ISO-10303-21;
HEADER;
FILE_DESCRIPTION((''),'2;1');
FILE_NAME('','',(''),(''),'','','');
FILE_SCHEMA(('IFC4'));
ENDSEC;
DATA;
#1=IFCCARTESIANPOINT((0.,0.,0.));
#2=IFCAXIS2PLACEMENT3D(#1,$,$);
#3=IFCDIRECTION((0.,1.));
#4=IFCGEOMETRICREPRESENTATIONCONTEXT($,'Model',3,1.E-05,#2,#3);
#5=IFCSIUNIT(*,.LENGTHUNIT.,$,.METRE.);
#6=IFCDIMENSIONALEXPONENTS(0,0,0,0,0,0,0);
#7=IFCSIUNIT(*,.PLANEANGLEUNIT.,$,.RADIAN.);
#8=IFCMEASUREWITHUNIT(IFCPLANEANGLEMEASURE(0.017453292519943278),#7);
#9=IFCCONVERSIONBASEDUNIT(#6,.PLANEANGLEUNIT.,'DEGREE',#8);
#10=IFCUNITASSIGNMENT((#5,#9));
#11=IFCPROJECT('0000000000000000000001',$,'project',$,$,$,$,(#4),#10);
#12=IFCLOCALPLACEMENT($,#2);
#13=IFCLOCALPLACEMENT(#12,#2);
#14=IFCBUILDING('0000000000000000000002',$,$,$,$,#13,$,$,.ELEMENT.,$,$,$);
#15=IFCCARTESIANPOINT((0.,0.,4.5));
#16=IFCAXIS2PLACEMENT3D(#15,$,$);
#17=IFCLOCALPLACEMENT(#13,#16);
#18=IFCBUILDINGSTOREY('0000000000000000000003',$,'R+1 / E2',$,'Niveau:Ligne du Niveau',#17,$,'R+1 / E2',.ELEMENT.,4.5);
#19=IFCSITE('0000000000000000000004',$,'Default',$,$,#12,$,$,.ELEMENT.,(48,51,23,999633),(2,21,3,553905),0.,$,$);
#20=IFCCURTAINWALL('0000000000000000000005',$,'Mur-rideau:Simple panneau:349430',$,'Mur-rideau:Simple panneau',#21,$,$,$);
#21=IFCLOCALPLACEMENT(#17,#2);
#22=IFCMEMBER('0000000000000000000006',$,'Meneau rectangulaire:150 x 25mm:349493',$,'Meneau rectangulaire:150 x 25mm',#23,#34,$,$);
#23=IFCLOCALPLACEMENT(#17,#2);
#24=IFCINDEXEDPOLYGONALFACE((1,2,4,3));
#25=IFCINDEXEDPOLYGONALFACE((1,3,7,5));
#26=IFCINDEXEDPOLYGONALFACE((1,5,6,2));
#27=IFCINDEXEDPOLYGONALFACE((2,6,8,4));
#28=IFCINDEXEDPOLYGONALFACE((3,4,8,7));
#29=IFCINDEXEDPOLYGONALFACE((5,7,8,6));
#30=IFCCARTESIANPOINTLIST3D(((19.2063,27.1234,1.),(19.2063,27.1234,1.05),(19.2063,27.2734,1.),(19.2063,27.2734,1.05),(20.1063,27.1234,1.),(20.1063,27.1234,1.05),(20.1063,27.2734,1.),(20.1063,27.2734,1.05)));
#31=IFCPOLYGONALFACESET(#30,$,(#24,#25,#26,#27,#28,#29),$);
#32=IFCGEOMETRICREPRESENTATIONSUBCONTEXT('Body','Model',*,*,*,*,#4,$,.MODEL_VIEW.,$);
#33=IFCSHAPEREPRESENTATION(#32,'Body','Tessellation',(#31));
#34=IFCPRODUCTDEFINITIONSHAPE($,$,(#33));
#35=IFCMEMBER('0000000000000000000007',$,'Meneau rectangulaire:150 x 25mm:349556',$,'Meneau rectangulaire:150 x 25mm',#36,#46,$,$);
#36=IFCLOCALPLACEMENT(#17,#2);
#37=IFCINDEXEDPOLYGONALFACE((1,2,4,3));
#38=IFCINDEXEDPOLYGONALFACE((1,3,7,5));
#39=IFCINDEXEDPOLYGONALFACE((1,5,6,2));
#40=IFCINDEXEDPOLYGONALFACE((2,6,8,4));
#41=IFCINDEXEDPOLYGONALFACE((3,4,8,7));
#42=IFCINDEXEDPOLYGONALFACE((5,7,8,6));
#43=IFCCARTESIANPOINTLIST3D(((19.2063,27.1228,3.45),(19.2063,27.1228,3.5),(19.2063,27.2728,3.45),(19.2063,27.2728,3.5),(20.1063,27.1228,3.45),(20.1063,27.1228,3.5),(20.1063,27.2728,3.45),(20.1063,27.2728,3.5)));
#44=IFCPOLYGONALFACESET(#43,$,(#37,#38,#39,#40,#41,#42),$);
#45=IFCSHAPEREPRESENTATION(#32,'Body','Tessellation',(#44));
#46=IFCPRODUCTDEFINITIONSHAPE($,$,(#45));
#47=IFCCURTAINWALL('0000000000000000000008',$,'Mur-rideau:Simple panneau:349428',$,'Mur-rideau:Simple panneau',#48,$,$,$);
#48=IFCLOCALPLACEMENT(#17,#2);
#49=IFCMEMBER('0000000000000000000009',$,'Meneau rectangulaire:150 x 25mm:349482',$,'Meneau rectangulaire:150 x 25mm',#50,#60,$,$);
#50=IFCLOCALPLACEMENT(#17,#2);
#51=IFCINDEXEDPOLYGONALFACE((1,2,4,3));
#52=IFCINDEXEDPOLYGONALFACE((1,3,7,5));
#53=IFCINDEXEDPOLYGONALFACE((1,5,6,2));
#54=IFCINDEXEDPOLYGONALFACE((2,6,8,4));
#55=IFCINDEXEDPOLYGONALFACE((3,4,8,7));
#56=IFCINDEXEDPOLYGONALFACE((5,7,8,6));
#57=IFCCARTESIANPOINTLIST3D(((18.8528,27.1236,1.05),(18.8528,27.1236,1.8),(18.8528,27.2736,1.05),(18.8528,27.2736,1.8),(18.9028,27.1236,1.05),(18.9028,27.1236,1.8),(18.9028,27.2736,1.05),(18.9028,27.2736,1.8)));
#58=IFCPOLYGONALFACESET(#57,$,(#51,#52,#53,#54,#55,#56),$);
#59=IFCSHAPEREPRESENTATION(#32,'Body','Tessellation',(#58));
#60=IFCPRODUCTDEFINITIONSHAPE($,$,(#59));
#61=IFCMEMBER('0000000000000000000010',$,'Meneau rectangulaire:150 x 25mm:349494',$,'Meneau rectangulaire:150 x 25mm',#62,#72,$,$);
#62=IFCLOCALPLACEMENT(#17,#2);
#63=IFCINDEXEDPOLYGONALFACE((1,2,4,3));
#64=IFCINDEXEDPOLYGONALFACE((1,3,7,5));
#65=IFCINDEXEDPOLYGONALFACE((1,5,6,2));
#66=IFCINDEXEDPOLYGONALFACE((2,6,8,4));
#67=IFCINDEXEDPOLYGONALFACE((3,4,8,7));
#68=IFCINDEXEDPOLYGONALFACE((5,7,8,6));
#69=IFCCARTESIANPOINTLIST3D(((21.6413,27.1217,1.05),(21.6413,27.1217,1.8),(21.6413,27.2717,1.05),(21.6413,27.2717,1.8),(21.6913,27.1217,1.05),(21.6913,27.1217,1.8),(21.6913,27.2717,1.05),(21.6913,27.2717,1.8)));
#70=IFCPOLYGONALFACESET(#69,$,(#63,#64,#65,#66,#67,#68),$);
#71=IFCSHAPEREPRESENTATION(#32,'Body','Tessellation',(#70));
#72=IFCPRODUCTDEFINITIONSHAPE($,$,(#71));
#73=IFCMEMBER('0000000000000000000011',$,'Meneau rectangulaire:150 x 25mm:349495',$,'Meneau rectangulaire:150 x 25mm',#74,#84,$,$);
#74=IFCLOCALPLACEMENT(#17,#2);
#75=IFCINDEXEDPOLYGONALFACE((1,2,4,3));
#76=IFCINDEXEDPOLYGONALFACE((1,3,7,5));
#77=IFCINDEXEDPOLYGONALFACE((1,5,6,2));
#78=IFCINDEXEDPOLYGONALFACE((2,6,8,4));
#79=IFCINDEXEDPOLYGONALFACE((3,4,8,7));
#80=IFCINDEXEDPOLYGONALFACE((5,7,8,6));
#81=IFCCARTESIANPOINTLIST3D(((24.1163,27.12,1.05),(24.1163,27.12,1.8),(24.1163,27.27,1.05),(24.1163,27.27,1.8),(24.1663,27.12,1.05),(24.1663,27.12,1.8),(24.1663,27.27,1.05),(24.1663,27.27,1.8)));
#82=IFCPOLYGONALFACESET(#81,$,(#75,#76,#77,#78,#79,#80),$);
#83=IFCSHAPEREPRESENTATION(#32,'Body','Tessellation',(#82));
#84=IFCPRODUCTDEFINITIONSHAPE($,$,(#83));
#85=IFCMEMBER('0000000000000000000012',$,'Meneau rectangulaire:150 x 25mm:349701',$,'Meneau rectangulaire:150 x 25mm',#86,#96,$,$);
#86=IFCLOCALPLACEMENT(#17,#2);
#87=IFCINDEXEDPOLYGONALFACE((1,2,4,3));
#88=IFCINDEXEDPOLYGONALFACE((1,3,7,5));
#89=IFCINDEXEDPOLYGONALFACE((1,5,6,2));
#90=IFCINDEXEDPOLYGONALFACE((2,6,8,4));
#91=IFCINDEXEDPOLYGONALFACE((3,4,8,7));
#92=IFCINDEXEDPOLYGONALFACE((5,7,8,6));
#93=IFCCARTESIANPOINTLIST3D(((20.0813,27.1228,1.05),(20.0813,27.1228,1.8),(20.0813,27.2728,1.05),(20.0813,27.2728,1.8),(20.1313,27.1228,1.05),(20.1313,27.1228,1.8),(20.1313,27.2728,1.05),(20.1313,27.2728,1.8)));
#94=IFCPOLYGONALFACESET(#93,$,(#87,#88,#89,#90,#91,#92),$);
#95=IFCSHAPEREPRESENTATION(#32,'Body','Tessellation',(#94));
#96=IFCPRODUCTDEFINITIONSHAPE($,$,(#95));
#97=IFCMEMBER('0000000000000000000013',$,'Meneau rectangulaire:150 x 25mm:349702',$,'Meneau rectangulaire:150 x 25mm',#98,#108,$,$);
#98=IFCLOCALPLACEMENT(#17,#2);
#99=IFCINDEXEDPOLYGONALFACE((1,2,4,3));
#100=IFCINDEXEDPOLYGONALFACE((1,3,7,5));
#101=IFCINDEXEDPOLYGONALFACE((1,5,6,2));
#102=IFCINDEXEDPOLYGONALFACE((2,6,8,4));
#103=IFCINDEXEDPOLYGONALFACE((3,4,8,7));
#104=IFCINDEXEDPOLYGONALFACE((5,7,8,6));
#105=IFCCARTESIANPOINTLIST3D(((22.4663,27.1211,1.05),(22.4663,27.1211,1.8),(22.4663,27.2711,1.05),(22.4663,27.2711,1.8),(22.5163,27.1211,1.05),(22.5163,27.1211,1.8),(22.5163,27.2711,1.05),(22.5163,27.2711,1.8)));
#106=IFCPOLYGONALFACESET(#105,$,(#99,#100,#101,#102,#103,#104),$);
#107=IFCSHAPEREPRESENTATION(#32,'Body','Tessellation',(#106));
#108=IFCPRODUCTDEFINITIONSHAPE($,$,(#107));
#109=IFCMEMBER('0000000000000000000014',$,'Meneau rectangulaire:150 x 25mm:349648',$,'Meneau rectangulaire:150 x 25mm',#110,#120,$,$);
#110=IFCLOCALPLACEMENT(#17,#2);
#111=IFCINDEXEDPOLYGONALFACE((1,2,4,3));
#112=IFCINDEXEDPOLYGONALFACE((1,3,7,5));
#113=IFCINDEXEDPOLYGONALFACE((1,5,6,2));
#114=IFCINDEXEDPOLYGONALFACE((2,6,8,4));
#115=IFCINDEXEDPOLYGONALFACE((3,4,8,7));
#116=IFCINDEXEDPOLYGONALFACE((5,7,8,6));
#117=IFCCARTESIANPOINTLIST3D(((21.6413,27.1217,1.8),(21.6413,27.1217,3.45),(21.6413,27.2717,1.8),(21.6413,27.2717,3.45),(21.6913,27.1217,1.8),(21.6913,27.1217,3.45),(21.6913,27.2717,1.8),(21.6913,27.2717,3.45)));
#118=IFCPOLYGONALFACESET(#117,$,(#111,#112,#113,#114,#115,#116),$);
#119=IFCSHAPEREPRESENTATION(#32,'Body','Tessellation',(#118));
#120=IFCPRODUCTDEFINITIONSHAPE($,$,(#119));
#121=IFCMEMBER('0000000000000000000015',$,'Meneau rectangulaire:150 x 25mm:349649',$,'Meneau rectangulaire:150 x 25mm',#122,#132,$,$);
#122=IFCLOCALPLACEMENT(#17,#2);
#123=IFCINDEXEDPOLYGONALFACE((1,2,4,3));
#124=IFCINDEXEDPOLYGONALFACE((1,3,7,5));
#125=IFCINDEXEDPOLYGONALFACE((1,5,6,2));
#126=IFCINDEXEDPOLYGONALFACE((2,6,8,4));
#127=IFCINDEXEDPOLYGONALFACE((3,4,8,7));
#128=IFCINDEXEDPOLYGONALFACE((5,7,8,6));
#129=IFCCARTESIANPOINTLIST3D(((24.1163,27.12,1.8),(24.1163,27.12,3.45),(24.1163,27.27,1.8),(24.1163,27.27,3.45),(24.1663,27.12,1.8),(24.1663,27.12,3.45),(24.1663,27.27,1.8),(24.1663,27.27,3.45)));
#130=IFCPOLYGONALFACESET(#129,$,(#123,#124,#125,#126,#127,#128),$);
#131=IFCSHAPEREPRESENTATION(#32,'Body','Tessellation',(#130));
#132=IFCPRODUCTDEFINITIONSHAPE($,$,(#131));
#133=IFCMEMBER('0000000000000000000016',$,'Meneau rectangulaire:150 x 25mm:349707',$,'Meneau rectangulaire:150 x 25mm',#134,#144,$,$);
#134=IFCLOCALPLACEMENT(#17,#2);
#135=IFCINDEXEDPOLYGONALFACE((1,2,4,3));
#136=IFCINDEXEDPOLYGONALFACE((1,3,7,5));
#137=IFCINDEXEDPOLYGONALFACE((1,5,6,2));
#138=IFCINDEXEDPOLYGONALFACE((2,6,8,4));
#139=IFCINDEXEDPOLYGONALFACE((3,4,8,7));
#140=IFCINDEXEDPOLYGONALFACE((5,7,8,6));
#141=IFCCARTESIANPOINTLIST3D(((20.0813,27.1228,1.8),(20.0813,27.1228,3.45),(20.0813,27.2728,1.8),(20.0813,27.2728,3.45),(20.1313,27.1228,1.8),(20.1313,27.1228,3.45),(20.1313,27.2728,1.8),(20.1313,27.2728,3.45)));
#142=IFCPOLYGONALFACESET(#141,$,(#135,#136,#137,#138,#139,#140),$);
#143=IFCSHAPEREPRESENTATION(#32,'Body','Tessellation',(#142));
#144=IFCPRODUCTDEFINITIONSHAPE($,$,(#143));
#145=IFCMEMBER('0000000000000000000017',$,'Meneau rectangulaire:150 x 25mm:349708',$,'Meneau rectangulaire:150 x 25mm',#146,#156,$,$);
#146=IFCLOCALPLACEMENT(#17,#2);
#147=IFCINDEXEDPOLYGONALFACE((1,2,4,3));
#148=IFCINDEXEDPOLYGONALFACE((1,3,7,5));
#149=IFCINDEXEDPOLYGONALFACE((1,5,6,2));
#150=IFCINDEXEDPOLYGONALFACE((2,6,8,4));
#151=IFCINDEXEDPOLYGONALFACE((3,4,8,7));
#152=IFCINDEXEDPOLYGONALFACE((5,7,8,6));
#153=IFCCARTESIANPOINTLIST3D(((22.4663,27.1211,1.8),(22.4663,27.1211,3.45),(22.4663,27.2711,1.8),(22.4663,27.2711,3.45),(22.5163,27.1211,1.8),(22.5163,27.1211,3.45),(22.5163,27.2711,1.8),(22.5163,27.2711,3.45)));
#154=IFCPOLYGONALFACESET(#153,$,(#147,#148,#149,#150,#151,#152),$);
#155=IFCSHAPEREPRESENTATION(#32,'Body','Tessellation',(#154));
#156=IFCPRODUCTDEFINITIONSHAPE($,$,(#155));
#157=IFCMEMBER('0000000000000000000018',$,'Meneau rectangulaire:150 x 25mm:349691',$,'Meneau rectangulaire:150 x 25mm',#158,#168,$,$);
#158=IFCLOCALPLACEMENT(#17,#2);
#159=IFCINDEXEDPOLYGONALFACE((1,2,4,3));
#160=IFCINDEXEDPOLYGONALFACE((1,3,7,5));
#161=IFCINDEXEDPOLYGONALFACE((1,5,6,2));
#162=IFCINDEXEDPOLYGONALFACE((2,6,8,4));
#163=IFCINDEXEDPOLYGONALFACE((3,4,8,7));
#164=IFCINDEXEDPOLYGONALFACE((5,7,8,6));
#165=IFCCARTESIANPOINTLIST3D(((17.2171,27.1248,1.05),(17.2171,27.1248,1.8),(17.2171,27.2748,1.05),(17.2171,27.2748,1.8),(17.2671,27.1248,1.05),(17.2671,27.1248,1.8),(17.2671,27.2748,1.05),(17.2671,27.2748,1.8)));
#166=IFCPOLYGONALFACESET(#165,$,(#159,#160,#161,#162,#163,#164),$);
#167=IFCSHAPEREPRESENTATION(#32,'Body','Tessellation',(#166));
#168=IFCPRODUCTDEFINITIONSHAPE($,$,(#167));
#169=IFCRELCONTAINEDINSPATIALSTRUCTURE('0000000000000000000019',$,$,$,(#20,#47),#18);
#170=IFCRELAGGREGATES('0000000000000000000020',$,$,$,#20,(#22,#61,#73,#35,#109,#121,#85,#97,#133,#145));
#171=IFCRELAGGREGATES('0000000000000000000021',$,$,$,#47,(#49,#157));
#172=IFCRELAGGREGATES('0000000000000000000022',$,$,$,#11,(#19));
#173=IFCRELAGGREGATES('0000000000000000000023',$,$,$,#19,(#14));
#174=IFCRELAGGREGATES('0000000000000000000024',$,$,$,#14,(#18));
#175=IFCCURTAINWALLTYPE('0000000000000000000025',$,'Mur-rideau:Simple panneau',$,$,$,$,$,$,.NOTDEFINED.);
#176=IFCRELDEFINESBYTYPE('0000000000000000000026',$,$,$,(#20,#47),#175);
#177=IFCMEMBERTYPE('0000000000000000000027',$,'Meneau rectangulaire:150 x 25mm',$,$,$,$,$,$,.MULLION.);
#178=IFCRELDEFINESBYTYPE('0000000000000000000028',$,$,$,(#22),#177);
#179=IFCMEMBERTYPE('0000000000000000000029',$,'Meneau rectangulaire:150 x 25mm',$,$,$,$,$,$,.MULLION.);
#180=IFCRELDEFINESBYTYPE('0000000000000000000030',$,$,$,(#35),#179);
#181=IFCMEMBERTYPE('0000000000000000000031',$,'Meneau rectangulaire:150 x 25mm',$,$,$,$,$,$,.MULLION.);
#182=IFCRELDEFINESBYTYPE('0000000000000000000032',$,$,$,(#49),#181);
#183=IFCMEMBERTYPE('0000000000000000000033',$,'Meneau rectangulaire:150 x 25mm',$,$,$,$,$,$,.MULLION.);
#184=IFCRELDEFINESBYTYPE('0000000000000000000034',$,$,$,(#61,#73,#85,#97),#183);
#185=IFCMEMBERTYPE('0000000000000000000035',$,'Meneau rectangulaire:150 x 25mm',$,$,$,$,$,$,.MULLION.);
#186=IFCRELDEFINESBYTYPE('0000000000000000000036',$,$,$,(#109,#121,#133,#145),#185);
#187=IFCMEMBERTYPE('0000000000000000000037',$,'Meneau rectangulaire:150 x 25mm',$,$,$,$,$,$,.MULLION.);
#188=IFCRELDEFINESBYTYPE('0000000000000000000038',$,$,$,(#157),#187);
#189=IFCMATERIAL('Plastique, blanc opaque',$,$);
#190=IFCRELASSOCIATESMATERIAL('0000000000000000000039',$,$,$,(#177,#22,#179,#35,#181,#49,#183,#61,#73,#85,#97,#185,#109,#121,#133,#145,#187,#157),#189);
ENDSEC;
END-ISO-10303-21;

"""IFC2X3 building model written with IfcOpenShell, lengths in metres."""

from ifc_helpers import new_model, entity, si_unit, converted_unit, direction, frame, origin, origin_2d_with_axis, place, context, subcontext, project, spatial, rectangle, extrude, source, transform, mapped, material, type_object, type_shapes, element, aggregate, save


model = new_model("IFC2X3")

# Units and contexts
model_context = context("Model", 3, precision=1e-05, world=origin(), true_north=direction((0.0, 1.0)))
body_context = subcontext(model_context, "Body", "Model", "MODEL_VIEW")
ifc_project = project(units=[si_unit("LENGTHUNIT", "METRE"), converted_unit("PLANEANGLEUNIT", "DEGREE", entity("IfcPlaneAngleMeasure", 0.017453292519943278), si_unit("PLANEANGLEUNIT", "RADIAN"), dimensions=[0, 0, 0, 0, 0, 0, 0])], contexts=[model_context])

# Site, building, storey
site_placement = place(None, origin())
site = spatial("IfcSite", under=ifc_project, at=site_placement, Name="Default", CompositionType="ELEMENT", RefLatitude=(48, 51, 23, 999633), RefLongitude=(2, 21, 3, 553905), RefElevation=0.0)
building_placement = place(site_placement, origin())
building = spatial("IfcBuilding", under=site, at=building_placement, CompositionType="ELEMENT")
storey_placement = place(building_placement, frame((0.0, 0.0, 4.5)))
storey = spatial("IfcBuildingStorey", under=building, at=storey_placement, Name="R+1 / E2", ObjectType="Niveau:Ligne du Niveau", LongName="R+1 / E2", CompositionType="ELEMENT", Elevation=4.5)

# Curtain wall, members
curtain_wall_type = type_object("IfcCurtainWallType", Name="Mur-rideau:Simple panneau", PredefinedType="NOTDEFINED")
curtain_wall_1_placement = place(storey_placement, frame((0.0, 0.0, -4.5)))
curtain_wall_1 = element("IfcCurtainWall", 1, at=curtain_wall_1_placement, inside=storey, type_object=curtain_wall_type, Name="Mur-rideau:Simple panneau:349430", ObjectType="Mur-rideau:Simple panneau")
ifc_material_1 = material(Name="Plastique, blanc opaque")
member_type_1 = type_object("IfcMemberType", Name="Meneau rectangulaire:150 x 25mm", PredefinedType="MULLION", material=ifc_material_1)
shared_shape_1 = source(origin(), body_context, "Body", "SweptSolid", [
    extrude(rectangle(XDim=0.05, YDim=0.15, at=origin_2d_with_axis()), frame((-0.025, 0.0, -0.9), z_axis=(0.0, 0.0, 1.0), x_axis=(-1.0, 0.0, 0.0)), (0.0, 0.0, 1.0), 0.9),
])
type_shapes(member_type_1, [shared_shape_1])
member_1_placement = place(curtain_wall_1_placement, frame((19.2063, 27.1984, 5.5), z_axis=(-1.0, 0.0, 0.0), x_axis=(0.0, 0.0, -1.0)))
member_1 = element("IfcMember", 2, at=member_1_placement, type_object=member_type_1, material=ifc_material_1, Name="Meneau rectangulaire:150 x 25mm:349493", ObjectType="Meneau rectangulaire:150 x 25mm", context=body_context, shape_type="MappedRepresentation", body=[
    mapped(shared_shape_1, transform((0.0, 0.0, 0.0), scale=1.0)),
])
member_type_2 = type_object("IfcMemberType", Name="Meneau rectangulaire:150 x 25mm", PredefinedType="MULLION", material=ifc_material_1)
shared_shape_2 = source(origin(), body_context, "Body", "SweptSolid", [
    extrude(rectangle(XDim=0.05, YDim=0.15, at=origin_2d_with_axis()), frame((-0.025, 0.0, -0.9), z_axis=(0.0, 0.0, 1.0), x_axis=(-1.0, 0.0, 0.0)), (0.0, 0.0, 1.0), 0.9),
])
type_shapes(member_type_2, [shared_shape_2])
member_2_placement = place(curtain_wall_1_placement, frame((20.1063, 27.1978, 8.0), z_axis=(1.0, 0.0, 0.0), x_axis=(0.0, 0.0, 1.0)))
member_2 = element("IfcMember", 3, at=member_2_placement, type_object=member_type_2, material=ifc_material_1, Name="Meneau rectangulaire:150 x 25mm:349556", ObjectType="Meneau rectangulaire:150 x 25mm", context=body_context, shape_type="MappedRepresentation", body=[
    mapped(shared_shape_2, transform((0.0, 0.0, 0.0), scale=1.0)),
])

# Curtain wall, member
curtain_wall_2_placement = place(storey_placement, frame((0.0, 0.0, -4.5)))
curtain_wall_2 = element("IfcCurtainWall", 4, at=curtain_wall_2_placement, inside=storey, type_object=curtain_wall_type, Name="Mur-rideau:Simple panneau:349428", ObjectType="Mur-rideau:Simple panneau")
member_type_3 = type_object("IfcMemberType", Name="Meneau rectangulaire:150 x 25mm", PredefinedType="MULLION", material=ifc_material_1)
shared_shape_3 = source(origin(), body_context, "Body", "SweptSolid", [
    extrude(rectangle(XDim=0.05, YDim=0.15, at=origin_2d_with_axis()), frame((-0.025, 0.0, -0.75), z_axis=(0.0, 0.0, 1.0), x_axis=(-1.0, 0.0, 0.0)), (0.0, 0.0, 1.0), 0.75),
])
type_shapes(member_type_3, [shared_shape_3])
member_3_placement = place(curtain_wall_2_placement, frame((18.9028, 27.1986, 5.55), z_axis=(0.0, 0.0, -1.0), x_axis=(1.0, 0.0, 0.0)))
member_3 = element("IfcMember", 5, at=member_3_placement, type_object=member_type_3, material=ifc_material_1, Name="Meneau rectangulaire:150 x 25mm:349482", ObjectType="Meneau rectangulaire:150 x 25mm", context=body_context, shape_type="MappedRepresentation", body=[
    mapped(shared_shape_3, transform((0.0, 0.0, 0.0), scale=1.0)),
])

# Members
member_type_4 = type_object("IfcMemberType", Name="Meneau rectangulaire:150 x 25mm", PredefinedType="MULLION", material=ifc_material_1)
shared_shape_4 = source(origin(), body_context, "Body", "SweptSolid", [
    extrude(rectangle(XDim=0.05, YDim=0.15, at=origin_2d_with_axis()), frame((0.0, 0.0, -0.75), z_axis=(0.0, 0.0, 1.0), x_axis=(-1.0, 0.0, 0.0)), (0.0, 0.0, 1.0), 0.75),
])
type_shapes(member_type_4, [shared_shape_4])
member_4_placement = place(curtain_wall_1_placement, frame((21.6663, 27.1967, 5.55), z_axis=(0.0, 0.0, -1.0), x_axis=(1.0, 0.0, 0.0)))
member_4 = element("IfcMember", 6, at=member_4_placement, type_object=member_type_4, material=ifc_material_1, Name="Meneau rectangulaire:150 x 25mm:349494", ObjectType="Meneau rectangulaire:150 x 25mm", context=body_context, shape_type="MappedRepresentation", body=[
    mapped(shared_shape_4, transform((0.0, 0.0, 0.0), scale=1.0)),
])
member_5_placement = place(curtain_wall_1_placement, frame((24.1413, 27.195, 5.55), z_axis=(0.0, 0.0, -1.0), x_axis=(1.0, 0.0, 0.0)))
member_5 = element("IfcMember", 7, at=member_5_placement, type_object=member_type_4, material=ifc_material_1, Name="Meneau rectangulaire:150 x 25mm:349495", ObjectType="Meneau rectangulaire:150 x 25mm", context=body_context, shape_type="MappedRepresentation", body=[
    mapped(shared_shape_4, transform((0.0, 0.0, 0.0), scale=1.0)),
])
member_6_placement = place(curtain_wall_1_placement, frame((20.1063, 27.1978, 5.55), z_axis=(0.0, 0.0, -1.0), x_axis=(1.0, 0.0, 0.0)))
member_6 = element("IfcMember", 8, at=member_6_placement, type_object=member_type_4, material=ifc_material_1, Name="Meneau rectangulaire:150 x 25mm:349701", ObjectType="Meneau rectangulaire:150 x 25mm", context=body_context, shape_type="MappedRepresentation", body=[
    mapped(shared_shape_4, transform((0.0, 0.0, 0.0), scale=1.0)),
])
member_7_placement = place(curtain_wall_1_placement, frame((22.4913, 27.1961, 5.55), z_axis=(0.0, 0.0, -1.0), x_axis=(1.0, 0.0, 0.0)))
member_7 = element("IfcMember", 9, at=member_7_placement, type_object=member_type_4, material=ifc_material_1, Name="Meneau rectangulaire:150 x 25mm:349702", ObjectType="Meneau rectangulaire:150 x 25mm", context=body_context, shape_type="MappedRepresentation", body=[
    mapped(shared_shape_4, transform((0.0, 0.0, 0.0), scale=1.0)),
])
member_type_5 = type_object("IfcMemberType", Name="Meneau rectangulaire:150 x 25mm", PredefinedType="MULLION", material=ifc_material_1)
shared_shape_5 = source(origin(), body_context, "Body", "SweptSolid", [
    extrude(rectangle(XDim=0.05, YDim=0.15, at=origin_2d_with_axis()), frame((0.0, 0.0, -1.65), z_axis=(0.0, 0.0, 1.0), x_axis=(-1.0, 0.0, 0.0)), (0.0, 0.0, 1.0), 1.65),
])
type_shapes(member_type_5, [shared_shape_5])
member_8_placement = place(curtain_wall_1_placement, frame((21.6663, 27.1967, 6.3), z_axis=(0.0, 0.0, -1.0), x_axis=(1.0, 0.0, 0.0)))
member_8 = element("IfcMember", 10, at=member_8_placement, type_object=member_type_5, material=ifc_material_1, Name="Meneau rectangulaire:150 x 25mm:349648", ObjectType="Meneau rectangulaire:150 x 25mm", context=body_context, shape_type="MappedRepresentation", body=[
    mapped(shared_shape_5, transform((0.0, 0.0, 0.0), scale=1.0)),
])
member_9_placement = place(curtain_wall_1_placement, frame((24.1413, 27.195, 6.3), z_axis=(0.0, 0.0, -1.0), x_axis=(1.0, 0.0, 0.0)))
member_9 = element("IfcMember", 11, at=member_9_placement, type_object=member_type_5, material=ifc_material_1, Name="Meneau rectangulaire:150 x 25mm:349649", ObjectType="Meneau rectangulaire:150 x 25mm", context=body_context, shape_type="MappedRepresentation", body=[
    mapped(shared_shape_5, transform((0.0, 0.0, 0.0), scale=1.0)),
])
member_10_placement = place(curtain_wall_1_placement, frame((20.1063, 27.1978, 6.3), z_axis=(0.0, 0.0, -1.0), x_axis=(1.0, 0.0, 0.0)))
member_10 = element("IfcMember", 12, at=member_10_placement, type_object=member_type_5, material=ifc_material_1, Name="Meneau rectangulaire:150 x 25mm:349707", ObjectType="Meneau rectangulaire:150 x 25mm", context=body_context, shape_type="MappedRepresentation", body=[
    mapped(shared_shape_5, transform((0.0, 0.0, 0.0), scale=1.0)),
])
member_11_placement = place(curtain_wall_1_placement, frame((22.4913, 27.1961, 6.3), z_axis=(0.0, 0.0, -1.0), x_axis=(1.0, 0.0, 0.0)))
member_11 = element("IfcMember", 13, at=member_11_placement, type_object=member_type_5, material=ifc_material_1, Name="Meneau rectangulaire:150 x 25mm:349708", ObjectType="Meneau rectangulaire:150 x 25mm", context=body_context, shape_type="MappedRepresentation", body=[
    mapped(shared_shape_5, transform((0.0, 0.0, 0.0), scale=1.0)),
])
member_type_6 = type_object("IfcMemberType", Name="Meneau rectangulaire:150 x 25mm", PredefinedType="MULLION", material=ifc_material_1)
shared_shape_6 = source(origin(), body_context, "Body", "SweptSolid", [
    extrude(rectangle(XDim=0.05, YDim=0.15, at=origin_2d_with_axis()), frame((0.0, 0.0, -0.75), z_axis=(0.0, 0.0, 1.0), x_axis=(-1.0, 0.0, 0.0)), (0.0, 0.0, 1.0), 0.75),
])
type_shapes(member_type_6, [shared_shape_6])
member_12_placement = place(curtain_wall_2_placement, frame((17.2421, 27.1998, 5.55), z_axis=(0.0, 0.0, -1.0), x_axis=(1.0, 0.0, 0.0)))
member_12 = element("IfcMember", 14, at=member_12_placement, type_object=member_type_6, material=ifc_material_1, Name="Meneau rectangulaire:150 x 25mm:349691", ObjectType="Meneau rectangulaire:150 x 25mm", context=body_context, shape_type="MappedRepresentation", body=[
    mapped(shared_shape_6, transform((0.0, 0.0, 0.0), scale=1.0)),
])

aggregate(curtain_wall_1, [member_1, member_4, member_5, member_2, member_8, member_9, member_6, member_7, member_10, member_11])
aggregate(curtain_wall_2, [member_3, member_12])

save(model, "model.ifc")
